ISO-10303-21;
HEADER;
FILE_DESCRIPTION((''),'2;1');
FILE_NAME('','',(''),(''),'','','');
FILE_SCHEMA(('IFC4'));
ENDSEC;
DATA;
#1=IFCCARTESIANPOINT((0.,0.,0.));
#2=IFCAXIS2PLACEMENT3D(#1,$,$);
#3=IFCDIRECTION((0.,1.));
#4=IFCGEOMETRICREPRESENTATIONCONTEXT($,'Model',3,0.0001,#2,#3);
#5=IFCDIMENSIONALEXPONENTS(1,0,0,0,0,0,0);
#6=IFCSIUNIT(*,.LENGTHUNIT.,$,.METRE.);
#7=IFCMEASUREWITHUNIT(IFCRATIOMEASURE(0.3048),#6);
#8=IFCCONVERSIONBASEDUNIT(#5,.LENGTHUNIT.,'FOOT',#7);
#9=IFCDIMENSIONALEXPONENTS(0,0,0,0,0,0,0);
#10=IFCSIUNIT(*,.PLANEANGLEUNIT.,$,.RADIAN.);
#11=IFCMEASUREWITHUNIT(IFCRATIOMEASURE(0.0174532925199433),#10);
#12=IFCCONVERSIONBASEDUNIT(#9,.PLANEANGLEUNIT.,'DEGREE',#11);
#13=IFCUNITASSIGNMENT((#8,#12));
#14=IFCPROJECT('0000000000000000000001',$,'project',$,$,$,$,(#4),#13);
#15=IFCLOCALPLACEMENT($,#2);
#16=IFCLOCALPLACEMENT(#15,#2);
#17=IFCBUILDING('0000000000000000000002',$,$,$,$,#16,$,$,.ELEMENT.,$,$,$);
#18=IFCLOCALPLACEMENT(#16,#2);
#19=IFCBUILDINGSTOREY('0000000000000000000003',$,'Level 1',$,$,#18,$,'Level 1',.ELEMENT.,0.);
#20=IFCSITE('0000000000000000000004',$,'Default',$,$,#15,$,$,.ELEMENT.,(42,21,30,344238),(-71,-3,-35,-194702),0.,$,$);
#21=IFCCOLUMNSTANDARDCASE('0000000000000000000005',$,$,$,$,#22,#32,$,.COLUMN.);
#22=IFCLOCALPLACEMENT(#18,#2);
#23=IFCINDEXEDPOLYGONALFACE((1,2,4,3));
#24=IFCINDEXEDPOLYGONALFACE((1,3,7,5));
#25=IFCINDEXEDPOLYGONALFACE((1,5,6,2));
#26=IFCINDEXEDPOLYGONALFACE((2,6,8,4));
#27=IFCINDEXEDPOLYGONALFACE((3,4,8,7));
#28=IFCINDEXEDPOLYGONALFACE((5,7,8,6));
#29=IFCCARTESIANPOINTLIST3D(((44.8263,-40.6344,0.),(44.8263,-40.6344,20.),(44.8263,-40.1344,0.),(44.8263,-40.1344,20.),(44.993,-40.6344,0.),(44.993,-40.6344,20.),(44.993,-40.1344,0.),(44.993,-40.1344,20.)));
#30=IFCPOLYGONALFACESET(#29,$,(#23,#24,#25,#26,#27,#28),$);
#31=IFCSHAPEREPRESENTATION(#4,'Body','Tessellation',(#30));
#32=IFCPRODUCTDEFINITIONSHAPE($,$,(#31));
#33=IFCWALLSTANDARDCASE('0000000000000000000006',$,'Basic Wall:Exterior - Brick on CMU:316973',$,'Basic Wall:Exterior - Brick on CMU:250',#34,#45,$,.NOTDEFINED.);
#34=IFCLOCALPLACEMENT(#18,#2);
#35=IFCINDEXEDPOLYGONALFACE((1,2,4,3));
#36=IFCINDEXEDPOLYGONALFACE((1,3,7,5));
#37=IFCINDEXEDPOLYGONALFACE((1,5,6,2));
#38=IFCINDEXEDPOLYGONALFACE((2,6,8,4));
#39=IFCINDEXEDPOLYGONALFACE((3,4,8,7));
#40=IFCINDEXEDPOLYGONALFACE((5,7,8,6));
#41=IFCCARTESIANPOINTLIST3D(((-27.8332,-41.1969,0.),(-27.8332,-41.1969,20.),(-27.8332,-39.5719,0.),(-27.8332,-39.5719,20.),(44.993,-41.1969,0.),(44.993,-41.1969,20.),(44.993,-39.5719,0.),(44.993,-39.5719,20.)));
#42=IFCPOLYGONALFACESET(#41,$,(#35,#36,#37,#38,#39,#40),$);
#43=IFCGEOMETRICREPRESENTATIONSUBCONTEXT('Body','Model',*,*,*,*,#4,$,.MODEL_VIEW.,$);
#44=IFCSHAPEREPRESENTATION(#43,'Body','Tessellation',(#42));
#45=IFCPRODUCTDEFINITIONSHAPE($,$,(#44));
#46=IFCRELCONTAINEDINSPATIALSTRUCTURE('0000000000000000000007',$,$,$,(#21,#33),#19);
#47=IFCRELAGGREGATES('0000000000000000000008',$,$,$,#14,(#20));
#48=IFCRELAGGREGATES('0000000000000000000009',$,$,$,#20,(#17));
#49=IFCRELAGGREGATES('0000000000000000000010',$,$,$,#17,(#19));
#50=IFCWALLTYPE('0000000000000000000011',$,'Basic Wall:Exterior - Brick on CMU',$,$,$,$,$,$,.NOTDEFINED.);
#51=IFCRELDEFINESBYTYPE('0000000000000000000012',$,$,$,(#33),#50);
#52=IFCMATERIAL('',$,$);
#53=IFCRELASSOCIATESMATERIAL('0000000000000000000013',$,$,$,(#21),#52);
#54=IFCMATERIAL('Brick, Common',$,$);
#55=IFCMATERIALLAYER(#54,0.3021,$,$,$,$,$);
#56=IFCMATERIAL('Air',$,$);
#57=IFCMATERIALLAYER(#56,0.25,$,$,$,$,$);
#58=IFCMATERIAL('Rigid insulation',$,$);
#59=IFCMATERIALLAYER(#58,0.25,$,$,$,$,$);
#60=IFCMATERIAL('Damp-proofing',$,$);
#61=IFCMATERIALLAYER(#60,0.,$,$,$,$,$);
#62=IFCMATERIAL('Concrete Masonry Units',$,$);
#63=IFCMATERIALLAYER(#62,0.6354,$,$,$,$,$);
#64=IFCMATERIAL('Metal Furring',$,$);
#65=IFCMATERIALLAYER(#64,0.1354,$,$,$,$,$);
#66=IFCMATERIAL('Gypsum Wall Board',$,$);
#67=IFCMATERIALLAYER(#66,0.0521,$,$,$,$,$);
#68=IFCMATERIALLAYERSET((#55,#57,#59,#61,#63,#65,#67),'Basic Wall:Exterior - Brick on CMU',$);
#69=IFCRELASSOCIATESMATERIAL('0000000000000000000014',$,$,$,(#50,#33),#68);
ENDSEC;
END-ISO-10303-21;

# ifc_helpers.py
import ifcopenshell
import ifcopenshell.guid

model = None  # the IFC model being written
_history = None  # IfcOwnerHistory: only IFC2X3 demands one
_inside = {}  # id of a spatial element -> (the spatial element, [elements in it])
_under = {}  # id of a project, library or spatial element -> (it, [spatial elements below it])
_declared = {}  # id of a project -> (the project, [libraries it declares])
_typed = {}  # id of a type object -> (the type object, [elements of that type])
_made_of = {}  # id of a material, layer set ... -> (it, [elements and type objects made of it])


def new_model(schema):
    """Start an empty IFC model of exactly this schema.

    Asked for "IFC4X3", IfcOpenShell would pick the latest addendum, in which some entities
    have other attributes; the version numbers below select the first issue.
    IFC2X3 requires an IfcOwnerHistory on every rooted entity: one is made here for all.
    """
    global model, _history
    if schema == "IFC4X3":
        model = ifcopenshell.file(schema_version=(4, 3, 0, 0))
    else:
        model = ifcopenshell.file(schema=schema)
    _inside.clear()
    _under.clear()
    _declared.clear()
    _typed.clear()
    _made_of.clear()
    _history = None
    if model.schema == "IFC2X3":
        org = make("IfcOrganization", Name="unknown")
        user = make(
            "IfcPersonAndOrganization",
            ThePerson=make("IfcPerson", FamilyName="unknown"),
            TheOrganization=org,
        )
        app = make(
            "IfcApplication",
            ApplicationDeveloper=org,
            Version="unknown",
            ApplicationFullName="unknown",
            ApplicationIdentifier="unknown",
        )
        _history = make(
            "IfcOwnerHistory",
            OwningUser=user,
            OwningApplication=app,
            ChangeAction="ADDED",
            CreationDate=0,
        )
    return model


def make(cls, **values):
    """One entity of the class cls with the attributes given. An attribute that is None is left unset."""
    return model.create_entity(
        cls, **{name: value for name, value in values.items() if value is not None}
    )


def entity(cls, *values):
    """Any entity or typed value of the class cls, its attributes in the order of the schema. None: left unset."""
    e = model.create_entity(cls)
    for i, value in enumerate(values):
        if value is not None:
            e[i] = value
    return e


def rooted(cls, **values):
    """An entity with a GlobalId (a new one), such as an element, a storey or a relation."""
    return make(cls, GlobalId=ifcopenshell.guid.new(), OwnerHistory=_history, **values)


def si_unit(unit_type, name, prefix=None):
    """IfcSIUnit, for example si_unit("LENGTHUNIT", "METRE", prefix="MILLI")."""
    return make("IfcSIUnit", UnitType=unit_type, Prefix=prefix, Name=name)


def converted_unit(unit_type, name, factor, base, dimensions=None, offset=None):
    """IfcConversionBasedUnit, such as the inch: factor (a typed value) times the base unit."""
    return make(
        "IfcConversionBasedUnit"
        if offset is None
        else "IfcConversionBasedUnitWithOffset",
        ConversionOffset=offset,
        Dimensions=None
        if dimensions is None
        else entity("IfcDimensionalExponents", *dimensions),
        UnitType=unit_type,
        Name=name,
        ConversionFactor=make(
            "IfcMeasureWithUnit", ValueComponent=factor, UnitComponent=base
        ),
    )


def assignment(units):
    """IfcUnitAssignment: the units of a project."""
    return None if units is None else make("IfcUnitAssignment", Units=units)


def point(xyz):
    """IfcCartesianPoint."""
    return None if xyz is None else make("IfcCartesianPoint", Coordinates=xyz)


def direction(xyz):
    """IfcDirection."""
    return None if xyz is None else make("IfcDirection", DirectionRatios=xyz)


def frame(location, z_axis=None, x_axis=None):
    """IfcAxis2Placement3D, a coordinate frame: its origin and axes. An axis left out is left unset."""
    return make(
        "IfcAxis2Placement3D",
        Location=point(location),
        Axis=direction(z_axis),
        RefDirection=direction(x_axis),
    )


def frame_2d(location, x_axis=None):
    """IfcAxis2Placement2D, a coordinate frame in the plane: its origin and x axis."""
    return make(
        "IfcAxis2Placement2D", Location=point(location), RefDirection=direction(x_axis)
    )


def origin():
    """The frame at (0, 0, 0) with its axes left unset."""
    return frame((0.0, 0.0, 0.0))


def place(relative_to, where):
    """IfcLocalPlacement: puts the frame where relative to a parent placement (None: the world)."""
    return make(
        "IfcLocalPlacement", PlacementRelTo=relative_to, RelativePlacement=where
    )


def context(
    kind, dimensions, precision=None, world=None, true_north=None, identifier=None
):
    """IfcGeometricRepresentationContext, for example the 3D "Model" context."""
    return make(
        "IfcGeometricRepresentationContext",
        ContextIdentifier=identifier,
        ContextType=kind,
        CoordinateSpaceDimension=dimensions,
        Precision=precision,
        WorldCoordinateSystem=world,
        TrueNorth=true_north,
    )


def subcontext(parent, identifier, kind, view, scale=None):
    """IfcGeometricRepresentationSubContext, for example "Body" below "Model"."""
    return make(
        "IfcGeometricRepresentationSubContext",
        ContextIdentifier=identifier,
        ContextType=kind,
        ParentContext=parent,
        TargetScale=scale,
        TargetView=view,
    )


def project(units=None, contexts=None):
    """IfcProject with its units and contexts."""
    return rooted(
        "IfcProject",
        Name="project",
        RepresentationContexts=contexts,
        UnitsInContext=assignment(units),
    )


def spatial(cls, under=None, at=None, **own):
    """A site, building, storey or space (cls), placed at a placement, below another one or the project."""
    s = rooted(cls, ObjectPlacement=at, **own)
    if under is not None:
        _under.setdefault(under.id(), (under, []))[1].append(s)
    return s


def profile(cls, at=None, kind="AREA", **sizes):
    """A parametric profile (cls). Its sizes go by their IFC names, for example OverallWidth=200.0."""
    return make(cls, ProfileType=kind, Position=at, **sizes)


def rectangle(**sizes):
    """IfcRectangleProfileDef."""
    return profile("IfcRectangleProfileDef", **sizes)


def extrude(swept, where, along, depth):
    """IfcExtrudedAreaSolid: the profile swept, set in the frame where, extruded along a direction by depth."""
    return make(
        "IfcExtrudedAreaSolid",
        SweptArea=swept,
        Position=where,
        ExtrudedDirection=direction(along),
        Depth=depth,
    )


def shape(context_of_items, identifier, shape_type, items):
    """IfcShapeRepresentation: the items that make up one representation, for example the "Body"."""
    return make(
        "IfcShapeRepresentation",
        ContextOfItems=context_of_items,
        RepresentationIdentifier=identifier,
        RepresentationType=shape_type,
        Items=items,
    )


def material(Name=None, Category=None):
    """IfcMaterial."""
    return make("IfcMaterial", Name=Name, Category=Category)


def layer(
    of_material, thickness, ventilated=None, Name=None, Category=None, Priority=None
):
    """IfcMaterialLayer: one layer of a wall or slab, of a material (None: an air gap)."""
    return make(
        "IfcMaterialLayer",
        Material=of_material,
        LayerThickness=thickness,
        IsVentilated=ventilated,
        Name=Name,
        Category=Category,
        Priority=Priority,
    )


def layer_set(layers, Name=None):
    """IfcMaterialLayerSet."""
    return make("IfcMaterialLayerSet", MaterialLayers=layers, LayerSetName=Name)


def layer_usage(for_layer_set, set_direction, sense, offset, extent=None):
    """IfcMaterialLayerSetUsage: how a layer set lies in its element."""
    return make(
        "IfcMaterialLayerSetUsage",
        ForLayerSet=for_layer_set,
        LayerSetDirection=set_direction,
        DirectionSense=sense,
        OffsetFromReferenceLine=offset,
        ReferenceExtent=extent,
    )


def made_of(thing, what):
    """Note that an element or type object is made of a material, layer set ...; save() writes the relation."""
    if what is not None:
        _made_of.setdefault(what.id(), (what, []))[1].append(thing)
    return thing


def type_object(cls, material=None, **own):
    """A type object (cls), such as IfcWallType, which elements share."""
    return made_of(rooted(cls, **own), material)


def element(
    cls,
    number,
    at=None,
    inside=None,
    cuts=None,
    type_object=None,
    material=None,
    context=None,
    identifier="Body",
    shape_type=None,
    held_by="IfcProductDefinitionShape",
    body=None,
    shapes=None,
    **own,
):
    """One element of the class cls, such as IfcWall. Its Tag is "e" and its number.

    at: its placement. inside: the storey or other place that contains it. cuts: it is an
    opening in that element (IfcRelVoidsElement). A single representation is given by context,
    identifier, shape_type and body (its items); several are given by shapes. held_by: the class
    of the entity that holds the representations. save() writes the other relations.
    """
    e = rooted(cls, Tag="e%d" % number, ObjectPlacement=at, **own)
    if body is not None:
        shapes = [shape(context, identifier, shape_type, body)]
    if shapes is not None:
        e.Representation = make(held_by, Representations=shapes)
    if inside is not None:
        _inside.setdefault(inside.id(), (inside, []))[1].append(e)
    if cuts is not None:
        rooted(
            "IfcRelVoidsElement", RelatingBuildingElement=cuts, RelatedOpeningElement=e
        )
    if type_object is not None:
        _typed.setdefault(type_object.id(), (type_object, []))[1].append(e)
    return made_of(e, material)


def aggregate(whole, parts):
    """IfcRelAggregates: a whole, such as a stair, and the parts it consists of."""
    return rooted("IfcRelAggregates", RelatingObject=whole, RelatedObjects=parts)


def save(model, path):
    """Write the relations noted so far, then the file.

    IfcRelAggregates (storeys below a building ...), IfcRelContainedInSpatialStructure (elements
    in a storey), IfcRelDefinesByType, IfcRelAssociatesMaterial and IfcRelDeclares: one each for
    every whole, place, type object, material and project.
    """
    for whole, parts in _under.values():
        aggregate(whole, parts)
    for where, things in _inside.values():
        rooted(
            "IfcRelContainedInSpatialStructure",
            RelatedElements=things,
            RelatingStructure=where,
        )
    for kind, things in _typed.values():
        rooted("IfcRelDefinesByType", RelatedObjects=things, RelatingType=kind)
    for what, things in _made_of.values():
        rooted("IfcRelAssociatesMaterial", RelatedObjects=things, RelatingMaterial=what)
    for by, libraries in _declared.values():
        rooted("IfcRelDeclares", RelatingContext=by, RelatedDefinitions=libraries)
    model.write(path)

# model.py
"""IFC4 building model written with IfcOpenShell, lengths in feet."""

from ifc_helpers import new_model, entity, si_unit, converted_unit, direction, frame, frame_2d, origin, place, context, subcontext, project, spatial, rectangle, extrude, material, layer, layer_set, layer_usage, type_object, element, save


model = new_model("IFC4")

# Units and contexts
model_context = context("Model", 3, precision=0.0001, world=origin(), true_north=direction((0.0, 1.0)))
body_context = subcontext(model_context, "Body", "Model", "MODEL_VIEW")
ifc_project = project(units=[converted_unit("LENGTHUNIT", "FOOT", entity("IfcRatioMeasure", 0.3048), si_unit("LENGTHUNIT", "METRE"), dimensions=[1, 0, 0, 0, 0, 0, 0]), converted_unit("PLANEANGLEUNIT", "DEGREE", entity("IfcRatioMeasure", 0.0174532925199433), si_unit("PLANEANGLEUNIT", "RADIAN"), dimensions=[0, 0, 0, 0, 0, 0, 0])], contexts=[model_context])

# Site, building, storey
site_placement = place(None, origin())
site = spatial("IfcSite", under=ifc_project, at=site_placement, Name="Default", CompositionType="ELEMENT", RefLatitude=(42, 21, 30, 344238), RefLongitude=(-71, -3, -35, -194702), RefElevation=0.0)
building_placement = place(site_placement, origin())
building = spatial("IfcBuilding", under=site, at=building_placement, CompositionType="ELEMENT")
storey_placement = place(building_placement, origin())
storey = spatial("IfcBuildingStorey", under=building, at=storey_placement, Name="Level 1", LongName="Level 1", CompositionType="ELEMENT", Elevation=0.0)

# Column
ifc_material_1 = material(Name="")
wall_placement = place(storey_placement, frame((44.993, -40.3844, 0.0), z_axis=(0.0, 0.0, 1.0), x_axis=(-1.0, 0.0, 0.0)))
for number, where, z_axis, x_axis in (
    (1, (0.0833, 0.0, 0.0), (0.0, 0.0, 1.0), (1.0, 0.0, 0.0)),
):
    element("IfcColumnStandardCase", number, at=place(wall_placement, frame(where, z_axis=z_axis, x_axis=x_axis)), inside=storey, material=ifc_material_1, PredefinedType="COLUMN", context=model_context, shape_type="SweptSolid", body=[
        extrude(rectangle(XDim=0.1667, YDim=0.5), origin(), (0.0, 0.0, 1.0), 20.0),
    ])

# Wall
ifc_material_2 = material(Name="Brick, Common")
ifc_layer_1 = layer(ifc_material_2, 0.3021)
ifc_material_3 = material(Name="Air")
ifc_layer_2 = layer(ifc_material_3, 0.25)
ifc_material_4 = material(Name="Rigid insulation")
ifc_layer_3 = layer(ifc_material_4, 0.25)
ifc_material_5 = material(Name="Damp-proofing")
ifc_layer_4 = layer(ifc_material_5, 0.0)
ifc_material_6 = material(Name="Concrete Masonry Units")
ifc_layer_5 = layer(ifc_material_6, 0.6354)
ifc_material_7 = material(Name="Metal Furring")
ifc_layer_6 = layer(ifc_material_7, 0.1354)
ifc_material_8 = material(Name="Gypsum Wall Board")
ifc_layer_7 = layer(ifc_material_8, 0.0521)
ifc_layer_set = layer_set([ifc_layer_1, ifc_layer_2, ifc_layer_3, ifc_layer_4, ifc_layer_5, ifc_layer_6, ifc_layer_7], Name="Basic Wall:Exterior - Brick on CMU")
ifc_layer_usage = layer_usage(ifc_layer_set, "AXIS2", "NEGATIVE", 0.8125)
wall_type = type_object("IfcWallType", Name="Basic Wall:Exterior - Brick on CMU", PredefinedType="NOTDEFINED", material=ifc_layer_set)
element("IfcWallStandardCase", 2, at=wall_placement, inside=storey, type_object=wall_type, material=ifc_layer_usage, Name="Basic Wall:Exterior - Brick on CMU:316973", ObjectType="Basic Wall:Exterior - Brick on CMU:250", PredefinedType="NOTDEFINED", context=body_context, shape_type="SweptSolid", body=[
    extrude(rectangle(XDim=72.8262, YDim=1.625, at=frame_2d((36.4131, 0.0), x_axis=(-1.0, 0.0))), origin(), (0.0, 0.0, 1.0), 20.0),
])

save(model, "model.ifc")
